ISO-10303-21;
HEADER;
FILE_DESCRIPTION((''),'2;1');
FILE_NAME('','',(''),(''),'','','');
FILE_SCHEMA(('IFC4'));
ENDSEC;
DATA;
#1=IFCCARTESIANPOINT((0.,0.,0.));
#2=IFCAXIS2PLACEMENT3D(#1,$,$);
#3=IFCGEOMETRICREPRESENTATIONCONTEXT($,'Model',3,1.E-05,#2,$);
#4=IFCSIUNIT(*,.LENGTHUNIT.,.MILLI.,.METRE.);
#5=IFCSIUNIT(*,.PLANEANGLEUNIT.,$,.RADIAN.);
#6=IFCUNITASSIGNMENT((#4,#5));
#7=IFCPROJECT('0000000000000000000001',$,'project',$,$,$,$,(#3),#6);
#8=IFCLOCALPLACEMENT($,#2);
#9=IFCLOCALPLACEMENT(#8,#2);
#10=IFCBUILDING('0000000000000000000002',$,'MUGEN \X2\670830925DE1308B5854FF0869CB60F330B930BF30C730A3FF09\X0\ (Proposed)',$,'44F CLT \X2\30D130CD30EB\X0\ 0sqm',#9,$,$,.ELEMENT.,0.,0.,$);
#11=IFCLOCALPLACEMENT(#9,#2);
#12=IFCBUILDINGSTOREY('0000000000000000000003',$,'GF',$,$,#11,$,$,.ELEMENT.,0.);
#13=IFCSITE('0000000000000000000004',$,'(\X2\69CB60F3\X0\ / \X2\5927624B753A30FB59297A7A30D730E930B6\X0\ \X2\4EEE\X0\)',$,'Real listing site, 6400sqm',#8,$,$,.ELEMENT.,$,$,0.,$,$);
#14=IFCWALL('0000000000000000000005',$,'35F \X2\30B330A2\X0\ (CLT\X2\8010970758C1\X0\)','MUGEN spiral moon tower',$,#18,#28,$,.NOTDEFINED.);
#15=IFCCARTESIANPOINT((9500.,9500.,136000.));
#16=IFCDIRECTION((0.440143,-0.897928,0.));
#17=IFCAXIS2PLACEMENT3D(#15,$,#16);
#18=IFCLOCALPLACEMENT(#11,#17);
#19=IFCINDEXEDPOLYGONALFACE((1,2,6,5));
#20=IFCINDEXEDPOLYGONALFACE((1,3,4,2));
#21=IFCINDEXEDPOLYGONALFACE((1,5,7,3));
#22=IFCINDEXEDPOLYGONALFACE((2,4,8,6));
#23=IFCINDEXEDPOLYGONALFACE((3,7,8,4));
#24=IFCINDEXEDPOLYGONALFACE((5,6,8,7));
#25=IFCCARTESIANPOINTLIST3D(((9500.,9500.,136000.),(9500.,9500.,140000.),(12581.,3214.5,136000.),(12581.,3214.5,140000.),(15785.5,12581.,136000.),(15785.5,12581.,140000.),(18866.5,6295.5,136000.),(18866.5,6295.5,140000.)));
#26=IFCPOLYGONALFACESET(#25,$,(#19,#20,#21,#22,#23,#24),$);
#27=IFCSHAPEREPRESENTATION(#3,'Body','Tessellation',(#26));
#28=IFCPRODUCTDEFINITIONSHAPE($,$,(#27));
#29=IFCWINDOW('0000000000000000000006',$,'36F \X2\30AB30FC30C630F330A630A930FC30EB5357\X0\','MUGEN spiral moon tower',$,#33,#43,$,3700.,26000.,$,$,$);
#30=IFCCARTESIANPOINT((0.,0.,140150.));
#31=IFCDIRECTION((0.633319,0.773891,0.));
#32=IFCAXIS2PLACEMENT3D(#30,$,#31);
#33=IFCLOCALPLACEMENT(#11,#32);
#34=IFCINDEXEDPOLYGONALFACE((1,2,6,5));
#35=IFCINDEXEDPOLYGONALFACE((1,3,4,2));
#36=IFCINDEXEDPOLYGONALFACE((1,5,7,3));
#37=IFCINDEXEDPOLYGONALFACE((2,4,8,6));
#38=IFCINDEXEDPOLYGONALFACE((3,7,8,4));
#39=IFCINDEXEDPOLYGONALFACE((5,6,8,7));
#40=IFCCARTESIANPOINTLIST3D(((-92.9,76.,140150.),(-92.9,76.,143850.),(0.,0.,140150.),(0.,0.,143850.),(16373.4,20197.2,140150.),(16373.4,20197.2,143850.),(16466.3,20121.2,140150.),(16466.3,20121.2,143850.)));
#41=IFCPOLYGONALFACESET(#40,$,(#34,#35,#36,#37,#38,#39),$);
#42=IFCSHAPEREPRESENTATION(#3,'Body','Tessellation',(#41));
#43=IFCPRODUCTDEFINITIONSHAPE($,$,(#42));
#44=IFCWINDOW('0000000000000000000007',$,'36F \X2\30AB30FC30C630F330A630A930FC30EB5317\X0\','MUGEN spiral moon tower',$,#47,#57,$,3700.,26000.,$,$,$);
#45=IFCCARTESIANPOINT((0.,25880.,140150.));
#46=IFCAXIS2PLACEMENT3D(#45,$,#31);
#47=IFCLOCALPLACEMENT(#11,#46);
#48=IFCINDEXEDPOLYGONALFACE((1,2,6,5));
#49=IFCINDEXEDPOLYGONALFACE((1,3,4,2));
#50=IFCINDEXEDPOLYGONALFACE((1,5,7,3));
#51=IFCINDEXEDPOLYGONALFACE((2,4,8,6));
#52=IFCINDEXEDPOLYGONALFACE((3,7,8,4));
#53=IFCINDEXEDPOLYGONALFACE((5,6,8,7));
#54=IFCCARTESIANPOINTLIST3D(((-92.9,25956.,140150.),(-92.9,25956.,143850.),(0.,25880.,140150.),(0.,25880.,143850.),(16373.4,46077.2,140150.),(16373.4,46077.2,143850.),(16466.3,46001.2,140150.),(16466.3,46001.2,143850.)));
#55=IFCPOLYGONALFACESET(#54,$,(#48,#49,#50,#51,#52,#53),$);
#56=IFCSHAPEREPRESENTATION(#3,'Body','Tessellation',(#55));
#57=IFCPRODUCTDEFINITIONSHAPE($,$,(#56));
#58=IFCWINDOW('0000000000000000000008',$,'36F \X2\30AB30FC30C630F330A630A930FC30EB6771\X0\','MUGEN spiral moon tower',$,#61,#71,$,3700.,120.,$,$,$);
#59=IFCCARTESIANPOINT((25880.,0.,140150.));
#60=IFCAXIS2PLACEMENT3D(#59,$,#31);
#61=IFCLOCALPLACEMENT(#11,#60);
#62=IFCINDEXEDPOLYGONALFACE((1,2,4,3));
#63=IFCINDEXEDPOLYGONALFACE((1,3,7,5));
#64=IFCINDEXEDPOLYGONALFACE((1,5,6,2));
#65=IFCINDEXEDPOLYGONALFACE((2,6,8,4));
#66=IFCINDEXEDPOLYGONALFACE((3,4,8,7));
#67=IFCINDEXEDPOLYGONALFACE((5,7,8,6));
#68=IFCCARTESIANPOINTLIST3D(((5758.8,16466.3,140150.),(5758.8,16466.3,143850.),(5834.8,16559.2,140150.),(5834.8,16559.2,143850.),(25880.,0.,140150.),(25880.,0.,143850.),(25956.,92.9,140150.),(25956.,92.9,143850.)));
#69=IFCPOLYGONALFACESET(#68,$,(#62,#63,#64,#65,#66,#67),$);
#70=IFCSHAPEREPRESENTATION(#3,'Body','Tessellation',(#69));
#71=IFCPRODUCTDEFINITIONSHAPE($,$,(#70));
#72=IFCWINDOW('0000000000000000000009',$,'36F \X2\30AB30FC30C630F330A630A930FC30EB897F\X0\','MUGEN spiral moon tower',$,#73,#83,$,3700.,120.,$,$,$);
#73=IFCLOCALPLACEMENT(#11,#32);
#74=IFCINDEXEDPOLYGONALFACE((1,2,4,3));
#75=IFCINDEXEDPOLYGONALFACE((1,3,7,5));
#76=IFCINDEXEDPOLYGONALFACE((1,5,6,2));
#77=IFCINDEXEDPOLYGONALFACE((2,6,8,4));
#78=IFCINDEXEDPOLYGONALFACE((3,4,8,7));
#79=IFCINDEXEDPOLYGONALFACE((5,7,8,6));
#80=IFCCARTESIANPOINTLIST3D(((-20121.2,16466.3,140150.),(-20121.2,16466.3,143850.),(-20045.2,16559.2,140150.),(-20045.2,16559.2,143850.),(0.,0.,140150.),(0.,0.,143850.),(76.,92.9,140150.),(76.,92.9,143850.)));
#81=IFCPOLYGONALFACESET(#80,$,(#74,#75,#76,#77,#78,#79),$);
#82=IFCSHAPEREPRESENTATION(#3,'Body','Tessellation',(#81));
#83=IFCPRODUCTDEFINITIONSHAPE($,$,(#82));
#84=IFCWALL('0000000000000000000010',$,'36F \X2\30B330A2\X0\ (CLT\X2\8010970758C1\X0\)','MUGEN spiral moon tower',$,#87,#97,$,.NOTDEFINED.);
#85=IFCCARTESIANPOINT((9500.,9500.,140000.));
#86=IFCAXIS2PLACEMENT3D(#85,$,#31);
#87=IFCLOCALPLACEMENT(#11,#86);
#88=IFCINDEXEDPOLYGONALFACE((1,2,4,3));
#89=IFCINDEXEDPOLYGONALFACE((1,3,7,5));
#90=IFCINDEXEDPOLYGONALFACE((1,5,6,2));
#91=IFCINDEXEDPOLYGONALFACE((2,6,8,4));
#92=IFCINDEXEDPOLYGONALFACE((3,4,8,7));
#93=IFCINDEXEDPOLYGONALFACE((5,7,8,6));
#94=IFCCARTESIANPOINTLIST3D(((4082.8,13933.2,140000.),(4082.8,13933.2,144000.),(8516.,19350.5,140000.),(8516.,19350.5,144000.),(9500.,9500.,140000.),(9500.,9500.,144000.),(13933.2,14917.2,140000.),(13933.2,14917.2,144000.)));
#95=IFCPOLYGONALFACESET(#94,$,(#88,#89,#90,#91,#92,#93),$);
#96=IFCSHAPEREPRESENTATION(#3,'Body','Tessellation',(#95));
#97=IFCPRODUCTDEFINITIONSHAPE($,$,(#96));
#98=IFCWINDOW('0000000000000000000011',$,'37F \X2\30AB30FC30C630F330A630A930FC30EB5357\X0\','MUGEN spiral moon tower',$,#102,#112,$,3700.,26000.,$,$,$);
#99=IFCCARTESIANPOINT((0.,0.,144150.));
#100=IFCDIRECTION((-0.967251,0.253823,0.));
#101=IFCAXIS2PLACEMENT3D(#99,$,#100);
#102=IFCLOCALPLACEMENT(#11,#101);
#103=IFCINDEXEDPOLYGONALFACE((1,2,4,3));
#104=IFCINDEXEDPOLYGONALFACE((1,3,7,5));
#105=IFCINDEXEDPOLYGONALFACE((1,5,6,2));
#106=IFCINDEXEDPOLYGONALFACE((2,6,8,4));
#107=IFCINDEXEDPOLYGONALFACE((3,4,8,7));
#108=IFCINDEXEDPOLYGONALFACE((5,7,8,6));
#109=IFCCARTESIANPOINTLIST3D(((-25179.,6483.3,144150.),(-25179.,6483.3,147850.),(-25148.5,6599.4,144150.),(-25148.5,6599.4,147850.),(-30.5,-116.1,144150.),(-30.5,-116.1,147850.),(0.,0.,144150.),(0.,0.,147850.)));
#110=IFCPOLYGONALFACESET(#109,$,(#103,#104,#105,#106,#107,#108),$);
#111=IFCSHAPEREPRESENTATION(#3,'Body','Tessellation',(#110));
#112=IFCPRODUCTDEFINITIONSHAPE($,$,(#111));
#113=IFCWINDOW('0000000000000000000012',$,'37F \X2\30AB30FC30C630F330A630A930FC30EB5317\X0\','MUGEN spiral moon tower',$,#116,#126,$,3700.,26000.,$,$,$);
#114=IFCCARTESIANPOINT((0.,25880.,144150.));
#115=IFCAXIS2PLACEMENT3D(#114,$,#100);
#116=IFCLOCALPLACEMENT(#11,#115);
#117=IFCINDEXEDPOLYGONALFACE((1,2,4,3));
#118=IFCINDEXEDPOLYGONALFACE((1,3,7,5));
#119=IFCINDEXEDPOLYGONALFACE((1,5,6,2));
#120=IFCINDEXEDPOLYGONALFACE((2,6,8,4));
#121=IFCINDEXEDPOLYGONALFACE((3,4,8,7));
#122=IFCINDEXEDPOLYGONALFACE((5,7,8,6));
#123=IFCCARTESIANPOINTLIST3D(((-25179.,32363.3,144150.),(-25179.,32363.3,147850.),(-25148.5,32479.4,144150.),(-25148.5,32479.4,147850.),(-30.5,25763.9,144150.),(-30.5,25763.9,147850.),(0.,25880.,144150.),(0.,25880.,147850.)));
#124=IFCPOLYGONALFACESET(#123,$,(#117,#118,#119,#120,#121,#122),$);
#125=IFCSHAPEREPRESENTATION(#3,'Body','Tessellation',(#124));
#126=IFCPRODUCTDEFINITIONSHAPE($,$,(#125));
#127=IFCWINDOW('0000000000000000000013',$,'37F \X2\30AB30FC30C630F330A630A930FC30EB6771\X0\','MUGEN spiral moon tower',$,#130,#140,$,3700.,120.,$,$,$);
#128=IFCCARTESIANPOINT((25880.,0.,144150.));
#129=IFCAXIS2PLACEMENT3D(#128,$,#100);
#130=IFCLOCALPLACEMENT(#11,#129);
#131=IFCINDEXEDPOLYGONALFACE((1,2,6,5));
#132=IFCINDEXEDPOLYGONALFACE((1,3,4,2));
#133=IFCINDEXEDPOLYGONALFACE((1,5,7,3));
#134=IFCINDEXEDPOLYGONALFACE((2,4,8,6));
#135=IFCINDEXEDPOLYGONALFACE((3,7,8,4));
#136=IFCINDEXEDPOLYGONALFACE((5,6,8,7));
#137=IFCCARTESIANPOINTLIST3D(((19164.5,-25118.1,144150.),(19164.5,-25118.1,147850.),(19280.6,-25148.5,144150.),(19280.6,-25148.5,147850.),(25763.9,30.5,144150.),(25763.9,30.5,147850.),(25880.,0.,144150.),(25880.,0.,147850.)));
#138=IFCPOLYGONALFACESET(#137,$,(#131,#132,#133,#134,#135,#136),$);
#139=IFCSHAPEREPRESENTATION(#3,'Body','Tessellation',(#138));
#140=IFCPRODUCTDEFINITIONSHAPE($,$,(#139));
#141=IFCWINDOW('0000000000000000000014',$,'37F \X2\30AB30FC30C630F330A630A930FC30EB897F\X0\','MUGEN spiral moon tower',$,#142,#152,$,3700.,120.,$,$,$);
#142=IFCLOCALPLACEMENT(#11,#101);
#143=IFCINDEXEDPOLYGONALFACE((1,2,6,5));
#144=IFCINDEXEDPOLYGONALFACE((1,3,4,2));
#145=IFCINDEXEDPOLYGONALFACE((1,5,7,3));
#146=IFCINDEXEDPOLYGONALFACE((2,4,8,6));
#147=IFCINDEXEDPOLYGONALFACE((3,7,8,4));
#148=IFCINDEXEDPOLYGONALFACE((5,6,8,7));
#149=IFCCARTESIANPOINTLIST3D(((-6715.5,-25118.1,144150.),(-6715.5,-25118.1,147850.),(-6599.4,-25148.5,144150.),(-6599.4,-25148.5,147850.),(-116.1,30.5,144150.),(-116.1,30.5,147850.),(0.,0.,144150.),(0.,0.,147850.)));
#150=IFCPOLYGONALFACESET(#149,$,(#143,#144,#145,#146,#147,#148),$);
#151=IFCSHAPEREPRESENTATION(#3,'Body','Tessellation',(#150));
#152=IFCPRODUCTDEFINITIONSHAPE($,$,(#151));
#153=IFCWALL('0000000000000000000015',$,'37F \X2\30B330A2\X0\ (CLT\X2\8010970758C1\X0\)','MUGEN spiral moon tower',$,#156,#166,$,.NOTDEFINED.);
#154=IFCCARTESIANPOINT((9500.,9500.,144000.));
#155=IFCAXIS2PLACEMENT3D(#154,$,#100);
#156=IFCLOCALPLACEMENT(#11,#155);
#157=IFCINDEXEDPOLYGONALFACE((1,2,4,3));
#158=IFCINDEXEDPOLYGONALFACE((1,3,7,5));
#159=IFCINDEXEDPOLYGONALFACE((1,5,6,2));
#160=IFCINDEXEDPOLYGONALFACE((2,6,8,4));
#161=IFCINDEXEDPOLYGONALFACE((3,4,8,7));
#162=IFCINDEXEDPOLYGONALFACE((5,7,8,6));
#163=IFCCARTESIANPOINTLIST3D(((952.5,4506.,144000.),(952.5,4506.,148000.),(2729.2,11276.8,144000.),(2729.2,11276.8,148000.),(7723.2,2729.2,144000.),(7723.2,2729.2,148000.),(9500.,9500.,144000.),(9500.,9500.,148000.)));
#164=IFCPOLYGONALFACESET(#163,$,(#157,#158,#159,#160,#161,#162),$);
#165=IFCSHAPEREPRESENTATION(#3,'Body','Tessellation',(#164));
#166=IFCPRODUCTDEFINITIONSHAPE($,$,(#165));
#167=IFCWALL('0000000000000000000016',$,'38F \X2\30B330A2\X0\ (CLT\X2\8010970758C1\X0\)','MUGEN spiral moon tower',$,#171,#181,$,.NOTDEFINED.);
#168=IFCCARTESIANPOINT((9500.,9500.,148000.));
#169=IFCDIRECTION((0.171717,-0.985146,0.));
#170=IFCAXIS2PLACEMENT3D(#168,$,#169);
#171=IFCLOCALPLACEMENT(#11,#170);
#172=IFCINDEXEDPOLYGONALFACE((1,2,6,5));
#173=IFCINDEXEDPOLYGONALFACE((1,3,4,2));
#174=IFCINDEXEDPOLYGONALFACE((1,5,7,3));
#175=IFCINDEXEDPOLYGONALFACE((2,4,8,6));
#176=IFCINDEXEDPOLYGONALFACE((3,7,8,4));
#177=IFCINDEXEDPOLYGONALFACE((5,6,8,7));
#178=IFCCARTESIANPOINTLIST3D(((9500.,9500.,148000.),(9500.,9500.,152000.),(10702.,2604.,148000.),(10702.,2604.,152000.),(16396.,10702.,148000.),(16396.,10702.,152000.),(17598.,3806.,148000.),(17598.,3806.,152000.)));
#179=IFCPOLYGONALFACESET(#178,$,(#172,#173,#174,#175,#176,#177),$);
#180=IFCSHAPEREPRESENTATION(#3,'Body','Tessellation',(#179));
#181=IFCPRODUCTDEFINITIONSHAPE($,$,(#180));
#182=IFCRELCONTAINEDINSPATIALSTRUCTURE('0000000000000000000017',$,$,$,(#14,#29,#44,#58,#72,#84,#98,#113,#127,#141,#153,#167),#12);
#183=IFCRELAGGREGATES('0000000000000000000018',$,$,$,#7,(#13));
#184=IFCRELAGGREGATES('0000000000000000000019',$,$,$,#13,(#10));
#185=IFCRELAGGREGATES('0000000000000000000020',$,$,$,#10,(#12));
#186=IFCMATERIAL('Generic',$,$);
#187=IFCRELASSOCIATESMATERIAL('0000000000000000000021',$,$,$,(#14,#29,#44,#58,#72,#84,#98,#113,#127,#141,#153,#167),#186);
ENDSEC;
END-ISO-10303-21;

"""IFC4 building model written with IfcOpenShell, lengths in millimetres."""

from ifc_helpers import new_model, si_unit, frame, frame_2d, origin, place, context, project, spatial, rectangle, extrude, material, element, save


model = new_model("IFC4")

# Units and contexts
model_context = context("Model", 3, precision=1e-05, world=origin())
ifc_project = project(units=[si_unit("LENGTHUNIT", "METRE", prefix="MILLI"), si_unit("PLANEANGLEUNIT", "RADIAN")], contexts=[model_context])

# Site, building, storey
site_placement = place(None, origin())
site = spatial("IfcSite", under=ifc_project, at=site_placement, Name="(構想 / 大手町・天空プラザ 仮)", ObjectType="Real listing site, 6400sqm", CompositionType="ELEMENT", RefElevation=0.0)
building_placement = place(site_placement, origin())
building = spatial("IfcBuilding", under=site, at=building_placement, Name="MUGEN 月を巡る塔（構想スタディ） (Proposed)", ObjectType="44F CLT パネル 0sqm", CompositionType="ELEMENT", ElevationOfRefHeight=0.0, ElevationOfTerrain=0.0)
storey_placement = place(building_placement, origin())
storey = spatial("IfcBuildingStorey", under=building, at=storey_placement, Name="GF", CompositionType="ELEMENT", Elevation=0.0)

# Shared definitions
ifc_material = material(Name="Generic")

# Wall
wall_1_placement = place(storey_placement, frame((9500.0, 9500.0, 136000.0), x_axis=(0.440143, -0.897928, 0.0)))
element("IfcWall", 1, at=wall_1_placement, inside=storey, material=ifc_material, Name="35F コア (CLT耐震壁)", Description="MUGEN spiral moon tower", PredefinedType="NOTDEFINED", context=model_context, shape_type="SweptSolid", body=[
    extrude(rectangle(XDim=7000.0, YDim=7000.0, at=frame_2d((3500.0, 3500.0))), frame((9500.0, 9500.0, 136000.0), x_axis=(0.440143, -0.897928, 0.0)), (0.0, 0.0, 1.0), 4000.0),
])

# Windows
window_1_placement = place(storey_placement, frame((0.0, 0.0, 140150.0), x_axis=(0.633319, 0.773891, 0.0)))
element("IfcWindow", 2, at=window_1_placement, inside=storey, material=ifc_material, Name="36F カーテンウォール南", Description="MUGEN spiral moon tower", OverallHeight=3700.0, OverallWidth=26000.0, context=model_context, shape_type="SweptSolid", body=[
    extrude(rectangle(XDim=26000.0, YDim=120.0, at=frame_2d((13000.0, 60.0))), frame((0.0, 0.0, 140150.0), x_axis=(0.633319, 0.773891, 0.0)), (0.0, 0.0, 1.0), 3700.0),
])
window_2_placement = place(storey_placement, frame((0.0, 25880.0, 140150.0), x_axis=(0.633319, 0.773891, 0.0)))
element("IfcWindow", 3, at=window_2_placement, inside=storey, material=ifc_material, Name="36F カーテンウォール北", Description="MUGEN spiral moon tower", OverallHeight=3700.0, OverallWidth=26000.0, context=model_context, shape_type="SweptSolid", body=[
    extrude(rectangle(XDim=26000.0, YDim=120.0, at=frame_2d((13000.0, 60.0))), frame((0.0, 25880.0, 140150.0), x_axis=(0.633319, 0.773891, 0.0)), (0.0, 0.0, 1.0), 3700.0),
])
window_3_placement = place(storey_placement, frame((25880.0, 0.0, 140150.0), x_axis=(0.633319, 0.773891, 0.0)))
element("IfcWindow", 4, at=window_3_placement, inside=storey, material=ifc_material, Name="36F カーテンウォール東", Description="MUGEN spiral moon tower", OverallHeight=3700.0, OverallWidth=120.0, context=model_context, shape_type="SweptSolid", body=[
    extrude(rectangle(XDim=120.0, YDim=26000.0, at=frame_2d((60.0, 13000.0))), frame((25880.0, 0.0, 140150.0), x_axis=(0.633319, 0.773891, 0.0)), (0.0, 0.0, 1.0), 3700.0),
])
window_4_placement = place(storey_placement, frame((0.0, 0.0, 140150.0), x_axis=(0.633319, 0.773891, 0.0)))
element("IfcWindow", 5, at=window_4_placement, inside=storey, material=ifc_material, Name="36F カーテンウォール西", Description="MUGEN spiral moon tower", OverallHeight=3700.0, OverallWidth=120.0, context=model_context, shape_type="SweptSolid", body=[
    extrude(rectangle(XDim=120.0, YDim=26000.0, at=frame_2d((60.0, 13000.0))), frame((0.0, 0.0, 140150.0), x_axis=(0.633319, 0.773891, 0.0)), (0.0, 0.0, 1.0), 3700.0),
])

# Wall
wall_2_placement = place(storey_placement, frame((9500.0, 9500.0, 140000.0), x_axis=(0.633319, 0.773891, 0.0)))
element("IfcWall", 6, at=wall_2_placement, inside=storey, material=ifc_material, Name="36F コア (CLT耐震壁)", Description="MUGEN spiral moon tower", PredefinedType="NOTDEFINED", context=model_context, shape_type="SweptSolid", body=[
    extrude(rectangle(XDim=7000.0, YDim=7000.0, at=frame_2d((3500.0, 3500.0))), frame((9500.0, 9500.0, 140000.0), x_axis=(0.633319, 0.773891, 0.0)), (0.0, 0.0, 1.0), 4000.0),
])

# Windows
window_5_placement = place(storey_placement, frame((0.0, 0.0, 144150.0), x_axis=(-0.967251, 0.253823, 0.0)))
element("IfcWindow", 7, at=window_5_placement, inside=storey, material=ifc_material, Name="37F カーテンウォール南", Description="MUGEN spiral moon tower", OverallHeight=3700.0, OverallWidth=26000.0, context=model_context, shape_type="SweptSolid", body=[
    extrude(rectangle(XDim=26000.0, YDim=120.0, at=frame_2d((13000.0, 60.0))), frame((0.0, 0.0, 144150.0), x_axis=(-0.967251, 0.253823, 0.0)), (0.0, 0.0, 1.0), 3700.0),
])
window_6_placement = place(storey_placement, frame((0.0, 25880.0, 144150.0), x_axis=(-0.967251, 0.253823, 0.0)))
element("IfcWindow", 8, at=window_6_placement, inside=storey, material=ifc_material, Name="37F カーテンウォール北", Description="MUGEN spiral moon tower", OverallHeight=3700.0, OverallWidth=26000.0, context=model_context, shape_type="SweptSolid", body=[
    extrude(rectangle(XDim=26000.0, YDim=120.0, at=frame_2d((13000.0, 60.0))), frame((0.0, 25880.0, 144150.0), x_axis=(-0.967251, 0.253823, 0.0)), (0.0, 0.0, 1.0), 3700.0),
])
window_7_placement = place(storey_placement, frame((25880.0, 0.0, 144150.0), x_axis=(-0.967251, 0.253823, 0.0)))
element("IfcWindow", 9, at=window_7_placement, inside=storey, material=ifc_material, Name="37F カーテンウォール東", Description="MUGEN spiral moon tower", OverallHeight=3700.0, OverallWidth=120.0, context=model_context, shape_type="SweptSolid", body=[
    extrude(rectangle(XDim=120.0, YDim=26000.0, at=frame_2d((60.0, 13000.0))), frame((25880.0, 0.0, 144150.0), x_axis=(-0.967251, 0.253823, 0.0)), (0.0, 0.0, 1.0), 3700.0),
])
window_8_placement = place(storey_placement, frame((0.0, 0.0, 144150.0), x_axis=(-0.967251, 0.253823, 0.0)))
element("IfcWindow", 10, at=window_8_placement, inside=storey, material=ifc_material, Name="37F カーテンウォール西", Description="MUGEN spiral moon tower", OverallHeight=3700.0, OverallWidth=120.0, context=model_context, shape_type="SweptSolid", body=[
    extrude(rectangle(XDim=120.0, YDim=26000.0, at=frame_2d((60.0, 13000.0))), frame((0.0, 0.0, 144150.0), x_axis=(-0.967251, 0.253823, 0.0)), (0.0, 0.0, 1.0), 3700.0),
])

# Walls
wall_3_placement = place(storey_placement, frame((9500.0, 9500.0, 144000.0), x_axis=(-0.967251, 0.253823, 0.0)))
element("IfcWall", 11, at=wall_3_placement, inside=storey, material=ifc_material, Name="37F コア (CLT耐震壁)", Description="MUGEN spiral moon tower", PredefinedType="NOTDEFINED", context=model_context, shape_type="SweptSolid", body=[
    extrude(rectangle(XDim=7000.0, YDim=7000.0, at=frame_2d((3500.0, 3500.0))), frame((9500.0, 9500.0, 144000.0), x_axis=(-0.967251, 0.253823, 0.0)), (0.0, 0.0, 1.0), 4000.0),
])
wall_4_placement = place(storey_placement, frame((9500.0, 9500.0, 148000.0), x_axis=(0.171717, -0.985146, 0.0)))
element("IfcWall", 12, at=wall_4_placement, inside=storey, material=ifc_material, Name="38F コア (CLT耐震壁)", Description="MUGEN spiral moon tower", PredefinedType="NOTDEFINED", context=model_context, shape_type="SweptSolid", body=[
    extrude(rectangle(XDim=7000.0, YDim=7000.0, at=frame_2d((3500.0, 3500.0))), frame((9500.0, 9500.0, 148000.0), x_axis=(0.171717, -0.985146, 0.0)), (0.0, 0.0, 1.0), 4000.0),
])

save(model, "model.ifc")
